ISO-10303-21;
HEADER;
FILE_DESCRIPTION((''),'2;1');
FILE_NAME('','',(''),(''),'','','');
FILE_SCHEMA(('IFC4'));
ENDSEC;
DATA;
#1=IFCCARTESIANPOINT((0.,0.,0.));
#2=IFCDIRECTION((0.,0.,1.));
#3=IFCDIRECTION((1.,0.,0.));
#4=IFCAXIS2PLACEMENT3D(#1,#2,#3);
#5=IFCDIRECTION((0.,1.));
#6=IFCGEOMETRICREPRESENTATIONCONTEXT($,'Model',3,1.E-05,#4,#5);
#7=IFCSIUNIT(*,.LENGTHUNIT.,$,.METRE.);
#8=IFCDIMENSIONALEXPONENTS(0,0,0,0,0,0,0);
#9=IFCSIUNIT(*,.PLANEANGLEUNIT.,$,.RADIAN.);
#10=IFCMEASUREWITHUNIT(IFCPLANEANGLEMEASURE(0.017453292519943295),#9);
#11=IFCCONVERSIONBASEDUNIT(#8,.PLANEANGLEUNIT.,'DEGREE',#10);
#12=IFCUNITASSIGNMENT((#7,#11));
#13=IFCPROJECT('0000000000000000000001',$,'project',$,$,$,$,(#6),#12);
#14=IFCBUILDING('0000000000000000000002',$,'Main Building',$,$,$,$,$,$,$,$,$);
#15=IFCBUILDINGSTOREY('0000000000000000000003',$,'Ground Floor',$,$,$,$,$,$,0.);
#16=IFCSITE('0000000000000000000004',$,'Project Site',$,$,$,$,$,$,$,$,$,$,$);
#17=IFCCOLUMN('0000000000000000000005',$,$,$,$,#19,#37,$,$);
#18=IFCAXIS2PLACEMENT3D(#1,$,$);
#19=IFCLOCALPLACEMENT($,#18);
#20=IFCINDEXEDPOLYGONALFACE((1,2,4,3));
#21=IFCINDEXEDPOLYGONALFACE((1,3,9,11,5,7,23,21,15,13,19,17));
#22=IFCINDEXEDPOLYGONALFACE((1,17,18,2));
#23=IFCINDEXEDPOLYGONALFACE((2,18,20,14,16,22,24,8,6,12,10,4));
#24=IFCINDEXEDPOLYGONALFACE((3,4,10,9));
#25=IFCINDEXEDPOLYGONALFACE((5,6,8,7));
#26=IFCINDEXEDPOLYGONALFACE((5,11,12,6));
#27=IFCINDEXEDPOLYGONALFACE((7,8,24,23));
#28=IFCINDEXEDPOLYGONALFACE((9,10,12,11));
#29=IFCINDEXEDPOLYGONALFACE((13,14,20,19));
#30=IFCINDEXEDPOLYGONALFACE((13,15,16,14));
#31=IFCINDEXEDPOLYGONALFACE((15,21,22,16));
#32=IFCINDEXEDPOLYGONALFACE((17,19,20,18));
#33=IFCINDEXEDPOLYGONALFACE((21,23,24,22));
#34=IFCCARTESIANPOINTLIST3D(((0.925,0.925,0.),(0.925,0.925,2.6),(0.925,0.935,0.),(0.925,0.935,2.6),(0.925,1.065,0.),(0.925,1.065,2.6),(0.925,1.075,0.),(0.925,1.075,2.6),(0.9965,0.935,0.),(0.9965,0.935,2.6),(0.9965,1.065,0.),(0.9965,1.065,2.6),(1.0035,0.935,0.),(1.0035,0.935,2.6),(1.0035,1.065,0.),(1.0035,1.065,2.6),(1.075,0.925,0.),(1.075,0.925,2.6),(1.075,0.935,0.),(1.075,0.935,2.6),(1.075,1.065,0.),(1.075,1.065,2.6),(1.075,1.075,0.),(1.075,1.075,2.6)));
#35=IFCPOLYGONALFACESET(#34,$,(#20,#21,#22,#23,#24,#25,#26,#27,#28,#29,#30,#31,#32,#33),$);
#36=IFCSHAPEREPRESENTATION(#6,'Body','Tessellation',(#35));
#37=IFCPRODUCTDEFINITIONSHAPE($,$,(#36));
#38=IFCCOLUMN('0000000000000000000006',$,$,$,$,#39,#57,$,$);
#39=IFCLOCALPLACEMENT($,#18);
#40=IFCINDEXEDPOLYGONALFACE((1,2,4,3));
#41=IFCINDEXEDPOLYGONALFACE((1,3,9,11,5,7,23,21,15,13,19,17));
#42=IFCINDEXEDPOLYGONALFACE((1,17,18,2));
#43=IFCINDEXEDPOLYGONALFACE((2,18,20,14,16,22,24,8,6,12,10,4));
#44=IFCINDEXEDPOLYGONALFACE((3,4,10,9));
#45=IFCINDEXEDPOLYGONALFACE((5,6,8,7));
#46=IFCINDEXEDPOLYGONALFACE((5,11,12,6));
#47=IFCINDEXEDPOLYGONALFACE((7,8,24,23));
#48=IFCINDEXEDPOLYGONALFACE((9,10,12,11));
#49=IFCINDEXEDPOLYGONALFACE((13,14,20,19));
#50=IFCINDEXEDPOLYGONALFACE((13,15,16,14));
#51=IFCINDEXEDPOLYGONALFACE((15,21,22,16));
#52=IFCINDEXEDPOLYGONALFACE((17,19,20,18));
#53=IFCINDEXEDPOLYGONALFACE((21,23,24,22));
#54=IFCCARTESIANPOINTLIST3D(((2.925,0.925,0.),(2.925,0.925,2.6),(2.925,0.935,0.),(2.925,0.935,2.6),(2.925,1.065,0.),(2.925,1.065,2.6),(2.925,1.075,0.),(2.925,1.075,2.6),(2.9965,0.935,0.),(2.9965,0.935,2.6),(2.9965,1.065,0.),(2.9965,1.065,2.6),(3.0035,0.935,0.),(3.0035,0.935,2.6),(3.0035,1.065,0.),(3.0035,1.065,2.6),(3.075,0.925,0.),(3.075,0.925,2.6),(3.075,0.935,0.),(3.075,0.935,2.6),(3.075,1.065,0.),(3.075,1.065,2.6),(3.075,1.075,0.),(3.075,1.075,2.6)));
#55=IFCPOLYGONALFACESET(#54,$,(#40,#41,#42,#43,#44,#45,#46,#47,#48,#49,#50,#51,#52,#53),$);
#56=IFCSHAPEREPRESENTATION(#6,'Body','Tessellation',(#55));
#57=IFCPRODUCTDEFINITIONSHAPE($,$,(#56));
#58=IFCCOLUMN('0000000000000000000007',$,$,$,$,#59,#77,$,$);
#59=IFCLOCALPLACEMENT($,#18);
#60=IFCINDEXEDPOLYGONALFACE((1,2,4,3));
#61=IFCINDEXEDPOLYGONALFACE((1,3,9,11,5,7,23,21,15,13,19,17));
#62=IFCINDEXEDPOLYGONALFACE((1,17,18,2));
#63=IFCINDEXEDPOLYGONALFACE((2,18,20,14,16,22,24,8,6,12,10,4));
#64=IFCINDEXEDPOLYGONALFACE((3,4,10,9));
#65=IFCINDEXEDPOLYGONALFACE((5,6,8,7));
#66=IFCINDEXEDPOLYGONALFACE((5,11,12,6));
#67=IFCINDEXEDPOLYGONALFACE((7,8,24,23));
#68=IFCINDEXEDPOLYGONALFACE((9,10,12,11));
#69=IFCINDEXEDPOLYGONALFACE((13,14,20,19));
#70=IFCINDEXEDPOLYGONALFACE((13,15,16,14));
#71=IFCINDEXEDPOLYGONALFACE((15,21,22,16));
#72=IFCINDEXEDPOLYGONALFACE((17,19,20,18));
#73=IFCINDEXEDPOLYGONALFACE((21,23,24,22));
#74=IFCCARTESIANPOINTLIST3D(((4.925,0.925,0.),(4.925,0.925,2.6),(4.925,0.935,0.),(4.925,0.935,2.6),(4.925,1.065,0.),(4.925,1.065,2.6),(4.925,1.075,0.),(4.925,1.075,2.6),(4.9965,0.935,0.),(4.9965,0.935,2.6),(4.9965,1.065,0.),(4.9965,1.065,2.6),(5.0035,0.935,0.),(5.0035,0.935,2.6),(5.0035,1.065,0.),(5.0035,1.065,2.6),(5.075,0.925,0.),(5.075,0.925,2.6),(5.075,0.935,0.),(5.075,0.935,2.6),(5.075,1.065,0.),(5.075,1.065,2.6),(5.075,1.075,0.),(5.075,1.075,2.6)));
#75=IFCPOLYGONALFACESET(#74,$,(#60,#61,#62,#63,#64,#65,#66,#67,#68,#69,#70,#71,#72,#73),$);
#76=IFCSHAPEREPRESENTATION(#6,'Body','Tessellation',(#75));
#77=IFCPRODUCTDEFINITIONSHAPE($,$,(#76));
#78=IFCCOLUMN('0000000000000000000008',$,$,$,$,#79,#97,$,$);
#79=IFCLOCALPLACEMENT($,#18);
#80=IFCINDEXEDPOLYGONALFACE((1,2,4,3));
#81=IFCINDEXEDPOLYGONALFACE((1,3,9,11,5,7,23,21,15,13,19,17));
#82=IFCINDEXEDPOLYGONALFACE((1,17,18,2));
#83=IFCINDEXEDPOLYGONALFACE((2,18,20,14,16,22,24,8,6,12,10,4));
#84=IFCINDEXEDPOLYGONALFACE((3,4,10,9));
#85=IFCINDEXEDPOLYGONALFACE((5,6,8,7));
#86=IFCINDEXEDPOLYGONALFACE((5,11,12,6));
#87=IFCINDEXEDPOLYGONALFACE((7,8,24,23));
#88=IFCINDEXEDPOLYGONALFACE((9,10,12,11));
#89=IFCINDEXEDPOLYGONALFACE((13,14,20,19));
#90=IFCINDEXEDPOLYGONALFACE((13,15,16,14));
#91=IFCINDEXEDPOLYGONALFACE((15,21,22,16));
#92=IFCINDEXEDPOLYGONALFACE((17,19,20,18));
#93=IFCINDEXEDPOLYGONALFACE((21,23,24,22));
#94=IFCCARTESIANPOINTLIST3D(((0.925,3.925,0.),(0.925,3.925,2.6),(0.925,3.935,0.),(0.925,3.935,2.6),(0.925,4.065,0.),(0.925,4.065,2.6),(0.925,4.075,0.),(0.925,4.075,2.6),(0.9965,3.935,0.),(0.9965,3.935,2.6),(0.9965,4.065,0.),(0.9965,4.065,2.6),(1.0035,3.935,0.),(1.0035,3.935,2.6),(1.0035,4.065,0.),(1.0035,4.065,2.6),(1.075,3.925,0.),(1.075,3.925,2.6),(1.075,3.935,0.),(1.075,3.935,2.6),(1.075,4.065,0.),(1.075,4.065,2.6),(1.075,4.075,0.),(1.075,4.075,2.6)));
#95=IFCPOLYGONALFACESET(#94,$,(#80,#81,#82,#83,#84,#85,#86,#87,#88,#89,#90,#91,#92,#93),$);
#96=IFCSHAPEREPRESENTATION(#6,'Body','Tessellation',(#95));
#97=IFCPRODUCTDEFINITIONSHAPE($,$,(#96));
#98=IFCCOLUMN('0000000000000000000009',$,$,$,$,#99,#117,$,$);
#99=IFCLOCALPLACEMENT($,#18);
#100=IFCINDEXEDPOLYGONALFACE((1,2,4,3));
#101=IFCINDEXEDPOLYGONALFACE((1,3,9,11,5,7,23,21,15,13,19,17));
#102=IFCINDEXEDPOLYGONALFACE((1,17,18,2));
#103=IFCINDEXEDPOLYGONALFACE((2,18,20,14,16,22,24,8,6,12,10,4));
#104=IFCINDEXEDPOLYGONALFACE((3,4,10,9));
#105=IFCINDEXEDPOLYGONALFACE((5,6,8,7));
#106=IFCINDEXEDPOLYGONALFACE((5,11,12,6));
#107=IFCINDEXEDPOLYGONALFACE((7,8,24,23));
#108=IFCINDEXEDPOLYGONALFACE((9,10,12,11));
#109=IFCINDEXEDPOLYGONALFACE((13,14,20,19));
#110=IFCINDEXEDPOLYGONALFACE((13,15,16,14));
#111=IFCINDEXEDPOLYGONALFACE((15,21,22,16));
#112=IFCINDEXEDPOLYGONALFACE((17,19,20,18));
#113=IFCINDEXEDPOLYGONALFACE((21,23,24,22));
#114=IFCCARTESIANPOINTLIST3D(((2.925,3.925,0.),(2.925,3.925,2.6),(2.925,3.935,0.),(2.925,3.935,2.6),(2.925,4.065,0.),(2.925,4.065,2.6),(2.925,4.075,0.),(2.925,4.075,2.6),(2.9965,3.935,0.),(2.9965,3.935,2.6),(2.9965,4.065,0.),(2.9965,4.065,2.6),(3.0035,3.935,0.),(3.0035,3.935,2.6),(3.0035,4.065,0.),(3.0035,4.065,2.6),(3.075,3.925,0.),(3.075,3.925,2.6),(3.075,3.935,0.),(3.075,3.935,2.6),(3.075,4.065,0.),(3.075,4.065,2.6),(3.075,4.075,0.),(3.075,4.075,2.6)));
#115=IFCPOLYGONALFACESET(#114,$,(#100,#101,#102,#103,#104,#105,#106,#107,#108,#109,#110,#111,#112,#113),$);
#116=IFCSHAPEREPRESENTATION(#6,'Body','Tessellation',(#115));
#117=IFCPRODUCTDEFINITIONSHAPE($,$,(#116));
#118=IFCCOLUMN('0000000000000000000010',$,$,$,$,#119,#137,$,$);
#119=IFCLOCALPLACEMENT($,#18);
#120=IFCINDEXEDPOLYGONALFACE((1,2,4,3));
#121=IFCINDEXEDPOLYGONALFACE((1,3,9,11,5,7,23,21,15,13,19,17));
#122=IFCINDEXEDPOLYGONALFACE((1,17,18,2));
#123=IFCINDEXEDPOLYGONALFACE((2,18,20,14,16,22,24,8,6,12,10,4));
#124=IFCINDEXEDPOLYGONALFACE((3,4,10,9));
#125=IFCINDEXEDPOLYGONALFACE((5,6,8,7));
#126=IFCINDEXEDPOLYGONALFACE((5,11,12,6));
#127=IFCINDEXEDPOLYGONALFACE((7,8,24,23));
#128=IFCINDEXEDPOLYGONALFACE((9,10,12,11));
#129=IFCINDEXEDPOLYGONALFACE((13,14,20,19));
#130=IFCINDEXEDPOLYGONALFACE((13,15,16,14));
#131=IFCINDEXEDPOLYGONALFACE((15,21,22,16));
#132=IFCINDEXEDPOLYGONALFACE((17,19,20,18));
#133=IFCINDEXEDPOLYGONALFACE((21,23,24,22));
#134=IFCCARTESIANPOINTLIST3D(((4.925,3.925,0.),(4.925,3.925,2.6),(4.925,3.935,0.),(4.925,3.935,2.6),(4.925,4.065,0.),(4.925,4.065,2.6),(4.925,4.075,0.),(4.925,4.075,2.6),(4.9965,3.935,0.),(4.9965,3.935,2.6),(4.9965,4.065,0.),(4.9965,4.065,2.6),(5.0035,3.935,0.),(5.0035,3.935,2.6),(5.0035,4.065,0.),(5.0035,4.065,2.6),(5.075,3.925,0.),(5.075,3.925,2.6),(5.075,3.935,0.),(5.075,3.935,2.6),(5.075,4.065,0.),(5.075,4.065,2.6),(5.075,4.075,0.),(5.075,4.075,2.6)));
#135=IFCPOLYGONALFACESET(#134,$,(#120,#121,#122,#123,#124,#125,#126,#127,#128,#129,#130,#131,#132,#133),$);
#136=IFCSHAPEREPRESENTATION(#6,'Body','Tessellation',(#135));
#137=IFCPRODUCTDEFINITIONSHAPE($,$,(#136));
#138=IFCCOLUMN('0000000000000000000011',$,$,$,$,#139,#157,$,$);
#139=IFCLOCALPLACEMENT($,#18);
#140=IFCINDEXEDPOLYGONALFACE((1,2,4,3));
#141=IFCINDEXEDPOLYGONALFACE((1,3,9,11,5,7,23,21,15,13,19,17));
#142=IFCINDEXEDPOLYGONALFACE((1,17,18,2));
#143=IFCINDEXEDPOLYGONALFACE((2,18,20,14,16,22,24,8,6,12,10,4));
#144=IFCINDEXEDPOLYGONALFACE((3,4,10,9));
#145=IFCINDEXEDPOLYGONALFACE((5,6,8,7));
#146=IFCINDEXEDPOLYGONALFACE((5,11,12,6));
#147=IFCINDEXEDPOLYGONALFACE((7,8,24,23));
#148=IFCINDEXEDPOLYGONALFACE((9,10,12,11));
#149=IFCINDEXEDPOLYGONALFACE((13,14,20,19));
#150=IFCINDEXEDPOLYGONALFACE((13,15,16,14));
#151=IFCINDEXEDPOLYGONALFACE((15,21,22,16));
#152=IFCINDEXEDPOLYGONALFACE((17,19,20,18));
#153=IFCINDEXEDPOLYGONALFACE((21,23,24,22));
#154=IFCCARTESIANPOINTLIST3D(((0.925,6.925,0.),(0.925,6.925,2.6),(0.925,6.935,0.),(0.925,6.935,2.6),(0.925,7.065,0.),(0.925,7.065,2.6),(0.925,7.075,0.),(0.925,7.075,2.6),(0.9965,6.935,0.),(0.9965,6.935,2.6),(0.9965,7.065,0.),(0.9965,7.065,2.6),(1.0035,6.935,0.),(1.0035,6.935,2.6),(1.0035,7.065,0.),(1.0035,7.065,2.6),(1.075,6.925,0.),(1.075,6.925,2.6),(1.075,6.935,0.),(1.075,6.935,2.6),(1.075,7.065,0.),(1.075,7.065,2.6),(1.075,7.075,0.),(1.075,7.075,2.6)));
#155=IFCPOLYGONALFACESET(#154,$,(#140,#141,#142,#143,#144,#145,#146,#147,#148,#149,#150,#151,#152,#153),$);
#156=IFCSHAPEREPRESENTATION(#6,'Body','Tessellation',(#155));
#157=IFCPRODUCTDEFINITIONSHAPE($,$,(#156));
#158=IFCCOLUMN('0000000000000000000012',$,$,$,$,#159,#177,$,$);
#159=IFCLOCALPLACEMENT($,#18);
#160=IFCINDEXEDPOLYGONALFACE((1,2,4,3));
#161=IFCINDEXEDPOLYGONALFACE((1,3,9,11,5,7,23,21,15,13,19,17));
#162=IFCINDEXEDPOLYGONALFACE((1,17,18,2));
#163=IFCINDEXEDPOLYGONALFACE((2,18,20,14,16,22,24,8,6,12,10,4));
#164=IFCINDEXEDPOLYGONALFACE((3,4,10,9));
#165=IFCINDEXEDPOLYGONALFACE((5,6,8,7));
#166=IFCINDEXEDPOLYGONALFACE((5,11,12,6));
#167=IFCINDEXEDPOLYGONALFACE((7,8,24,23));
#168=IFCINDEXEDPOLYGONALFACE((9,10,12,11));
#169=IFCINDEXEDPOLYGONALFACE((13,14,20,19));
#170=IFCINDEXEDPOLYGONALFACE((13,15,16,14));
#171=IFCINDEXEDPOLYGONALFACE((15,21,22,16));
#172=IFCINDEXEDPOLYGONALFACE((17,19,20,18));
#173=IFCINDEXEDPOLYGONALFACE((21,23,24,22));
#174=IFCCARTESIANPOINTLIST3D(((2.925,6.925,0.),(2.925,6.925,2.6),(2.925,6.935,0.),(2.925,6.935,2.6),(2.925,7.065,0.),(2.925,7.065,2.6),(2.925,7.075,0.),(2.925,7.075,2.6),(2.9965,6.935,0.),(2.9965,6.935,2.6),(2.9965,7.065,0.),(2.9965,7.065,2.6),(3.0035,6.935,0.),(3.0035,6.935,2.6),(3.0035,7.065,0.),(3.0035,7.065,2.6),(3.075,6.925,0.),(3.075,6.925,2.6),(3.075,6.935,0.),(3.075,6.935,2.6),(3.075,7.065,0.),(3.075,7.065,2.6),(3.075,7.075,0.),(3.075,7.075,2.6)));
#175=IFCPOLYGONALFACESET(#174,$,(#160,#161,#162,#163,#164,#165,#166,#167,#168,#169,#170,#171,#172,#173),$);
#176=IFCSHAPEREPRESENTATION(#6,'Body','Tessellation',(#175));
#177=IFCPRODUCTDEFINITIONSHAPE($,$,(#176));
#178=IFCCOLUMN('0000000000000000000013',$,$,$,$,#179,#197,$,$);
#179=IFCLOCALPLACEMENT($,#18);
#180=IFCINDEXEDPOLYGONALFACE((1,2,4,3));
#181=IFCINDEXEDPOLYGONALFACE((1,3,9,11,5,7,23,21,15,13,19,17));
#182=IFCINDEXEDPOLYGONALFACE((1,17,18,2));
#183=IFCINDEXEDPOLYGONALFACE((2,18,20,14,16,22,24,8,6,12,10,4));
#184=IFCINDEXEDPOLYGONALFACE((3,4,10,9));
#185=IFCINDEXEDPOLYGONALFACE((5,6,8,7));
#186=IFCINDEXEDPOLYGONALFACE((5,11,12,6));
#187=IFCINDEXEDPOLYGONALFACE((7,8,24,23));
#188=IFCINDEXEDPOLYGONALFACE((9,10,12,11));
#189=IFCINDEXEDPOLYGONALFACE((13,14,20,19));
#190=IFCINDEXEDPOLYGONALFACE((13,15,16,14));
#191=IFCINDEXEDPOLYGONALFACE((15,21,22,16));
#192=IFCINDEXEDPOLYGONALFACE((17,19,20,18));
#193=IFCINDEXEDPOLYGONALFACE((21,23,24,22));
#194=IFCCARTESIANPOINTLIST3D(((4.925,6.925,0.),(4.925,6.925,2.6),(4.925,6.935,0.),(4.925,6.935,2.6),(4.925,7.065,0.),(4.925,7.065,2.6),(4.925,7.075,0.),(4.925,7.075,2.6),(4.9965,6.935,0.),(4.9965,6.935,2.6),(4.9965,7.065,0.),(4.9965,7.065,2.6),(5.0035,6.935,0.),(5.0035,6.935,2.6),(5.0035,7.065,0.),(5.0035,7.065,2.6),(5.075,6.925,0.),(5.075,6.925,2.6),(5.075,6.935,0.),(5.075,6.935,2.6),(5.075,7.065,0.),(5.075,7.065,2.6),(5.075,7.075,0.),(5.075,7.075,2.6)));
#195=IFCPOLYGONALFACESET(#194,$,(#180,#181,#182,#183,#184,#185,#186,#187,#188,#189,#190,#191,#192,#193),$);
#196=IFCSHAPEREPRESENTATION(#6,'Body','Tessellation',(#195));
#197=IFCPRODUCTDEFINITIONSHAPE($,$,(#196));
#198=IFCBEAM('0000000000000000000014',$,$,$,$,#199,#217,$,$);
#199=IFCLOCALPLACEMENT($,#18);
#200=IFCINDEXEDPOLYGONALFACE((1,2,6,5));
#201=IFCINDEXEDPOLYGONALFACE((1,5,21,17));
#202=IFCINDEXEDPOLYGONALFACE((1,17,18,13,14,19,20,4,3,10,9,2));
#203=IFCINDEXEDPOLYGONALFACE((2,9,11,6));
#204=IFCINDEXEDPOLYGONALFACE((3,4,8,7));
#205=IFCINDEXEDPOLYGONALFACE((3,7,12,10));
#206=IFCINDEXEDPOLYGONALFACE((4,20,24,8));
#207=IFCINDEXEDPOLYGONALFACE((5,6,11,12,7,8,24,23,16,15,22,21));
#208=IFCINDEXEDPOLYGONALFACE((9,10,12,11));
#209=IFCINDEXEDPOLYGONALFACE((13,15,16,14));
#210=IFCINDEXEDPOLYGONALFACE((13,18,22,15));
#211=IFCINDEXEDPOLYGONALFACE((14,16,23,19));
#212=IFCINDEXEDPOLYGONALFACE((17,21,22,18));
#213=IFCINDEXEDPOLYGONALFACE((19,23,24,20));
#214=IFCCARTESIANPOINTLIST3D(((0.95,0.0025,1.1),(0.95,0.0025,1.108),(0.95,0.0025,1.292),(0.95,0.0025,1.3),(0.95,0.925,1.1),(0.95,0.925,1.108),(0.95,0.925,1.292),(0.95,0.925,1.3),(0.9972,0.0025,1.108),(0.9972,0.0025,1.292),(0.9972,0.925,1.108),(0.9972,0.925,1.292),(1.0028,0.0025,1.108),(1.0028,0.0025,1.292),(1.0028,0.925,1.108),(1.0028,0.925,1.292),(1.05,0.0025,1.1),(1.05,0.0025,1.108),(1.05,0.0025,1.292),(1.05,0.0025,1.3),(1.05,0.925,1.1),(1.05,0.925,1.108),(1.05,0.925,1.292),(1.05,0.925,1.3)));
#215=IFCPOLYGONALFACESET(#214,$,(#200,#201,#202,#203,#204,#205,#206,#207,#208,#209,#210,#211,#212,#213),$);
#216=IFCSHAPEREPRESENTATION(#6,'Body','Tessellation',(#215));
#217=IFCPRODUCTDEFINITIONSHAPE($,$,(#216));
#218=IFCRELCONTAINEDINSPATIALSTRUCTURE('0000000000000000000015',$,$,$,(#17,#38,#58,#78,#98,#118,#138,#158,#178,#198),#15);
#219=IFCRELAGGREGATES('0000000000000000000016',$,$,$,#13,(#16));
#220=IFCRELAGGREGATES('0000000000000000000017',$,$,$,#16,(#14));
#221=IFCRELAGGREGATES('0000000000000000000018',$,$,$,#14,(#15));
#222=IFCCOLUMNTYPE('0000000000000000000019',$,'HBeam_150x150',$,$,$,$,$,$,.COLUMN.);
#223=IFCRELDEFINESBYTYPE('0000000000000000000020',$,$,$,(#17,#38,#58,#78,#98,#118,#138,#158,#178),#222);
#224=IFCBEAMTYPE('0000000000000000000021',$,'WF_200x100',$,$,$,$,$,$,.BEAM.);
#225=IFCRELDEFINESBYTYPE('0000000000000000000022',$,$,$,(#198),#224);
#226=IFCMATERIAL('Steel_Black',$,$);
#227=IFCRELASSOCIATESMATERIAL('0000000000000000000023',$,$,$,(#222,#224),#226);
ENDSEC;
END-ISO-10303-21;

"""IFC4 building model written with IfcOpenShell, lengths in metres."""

from ifc_helpers import new_model, entity, si_unit, converted_unit, direction, frame, frame_2d, origin, origin_with_axes, origin_2d, place, context, project, spatial, i_section, extrude, material, material_profile, profile_set, type_object, element, save


model = new_model("IFC4")

# Units and contexts
model_context = context("Model", 3, precision=1e-05, world=origin_with_axes(), true_north=direction((0.0, 1.0)))
ifc_project = project(units=[si_unit("LENGTHUNIT", "METRE"), converted_unit("PLANEANGLEUNIT", "DEGREE", entity("IfcPlaneAngleMeasure", 0.017453292519943295), si_unit("PLANEANGLEUNIT", "RADIAN"), dimensions=[0, 0, 0, 0, 0, 0, 0])], contexts=[model_context])

# Site, building, storey
site = spatial("IfcSite", under=ifc_project, Name="Project Site")
building = spatial("IfcBuilding", under=site, Name="Main Building")
storey = spatial("IfcBuildingStorey", under=building, Name="Ground Floor", Elevation=0.0)

# Columns
ifc_material_1 = material(Name="Steel_Black")
ifc_material_profile_1 = material_profile(ifc_material_1, i_section(OverallWidth=0.15, OverallDepth=0.15, WebThickness=0.007, FlangeThickness=0.01, at=origin_2d()), Name="HBeam_150x150")
ifc_profile_set_1 = profile_set([ifc_material_profile_1], Name="HBeam_150x150")
column_type = type_object("IfcColumnType", Name="HBeam_150x150", PredefinedType="COLUMN", material=ifc_profile_set_1)
for number, where, z_axis, x_axis in (
    (1, (1.0, 1.0, 0.0), (0.0, 0.0, 1.0), (1.0, 0.0, 0.0)),
    (2, (3.0, 1.0, 0.0), (0.0, 0.0, 1.0), (1.0, 0.0, 0.0)),
    (3, (5.0, 1.0, 0.0), (0.0, 0.0, 1.0), (1.0, 0.0, 0.0)),
    (4, (1.0, 4.0, 0.0), (0.0, 0.0, 1.0), (1.0, 0.0, 0.0)),
    (5, (3.0, 4.0, 0.0), (0.0, 0.0, 1.0), (1.0, 0.0, 0.0)),
    (6, (5.0, 4.0, 0.0), (0.0, 0.0, 1.0), (1.0, 0.0, 0.0)),
    (7, (1.0, 7.0, 0.0), (0.0, 0.0, 1.0), (1.0, 0.0, 0.0)),
    (8, (3.0, 7.0, 0.0), (0.0, 0.0, 1.0), (1.0, 0.0, 0.0)),
    (9, (5.0, 7.0, 0.0), (0.0, 0.0, 1.0), (1.0, 0.0, 0.0)),
):
    element("IfcColumn", number, at=place(None, frame(where, z_axis=z_axis, x_axis=x_axis)), inside=storey, type_object=column_type, context=model_context, shape_type="SweptSolid", body=[
        extrude(i_section(OverallWidth=0.15, OverallDepth=0.15, WebThickness=0.007, FlangeThickness=0.01, at=origin_2d()), origin(), (0.0, 0.0, 1.0), 2.6),
    ])

# Beam
ifc_material_profile_2 = material_profile(ifc_material_1, i_section(OverallWidth=0.1, OverallDepth=0.2, WebThickness=0.0055, FlangeThickness=0.008, at=origin_2d()), Name="WF_200x100")
ifc_profile_set_2 = profile_set([ifc_material_profile_2], Name="WF_200x100")
beam_type_1 = type_object("IfcBeamType", Name="WF_200x100", PredefinedType="BEAM", material=ifc_profile_set_2)
for number, where, z_axis, x_axis in (
    (10, (1.0, 0.0025, 1.1), (0.0, 0.0, 1.0), (0.0, 1.0, 0.0)),
):
    element("IfcBeam", number, at=place(None, frame(where, z_axis=z_axis, x_axis=x_axis)), inside=storey, type_object=beam_type_1, context=model_context, shape_type="SweptSolid", body=[
        extrude(i_section(OverallWidth=0.1, OverallDepth=0.2, WebThickness=0.0055, FlangeThickness=0.008, at=frame_2d((0.0, 0.1))), frame((0.0, 0.0, 0.0), z_axis=(1.0, 0.0, 0.0), x_axis=(0.0, 1.0, 0.0)), (0.0, 0.0, 1.0), 0.9225),
    ])

save(model, "model.ifc")
